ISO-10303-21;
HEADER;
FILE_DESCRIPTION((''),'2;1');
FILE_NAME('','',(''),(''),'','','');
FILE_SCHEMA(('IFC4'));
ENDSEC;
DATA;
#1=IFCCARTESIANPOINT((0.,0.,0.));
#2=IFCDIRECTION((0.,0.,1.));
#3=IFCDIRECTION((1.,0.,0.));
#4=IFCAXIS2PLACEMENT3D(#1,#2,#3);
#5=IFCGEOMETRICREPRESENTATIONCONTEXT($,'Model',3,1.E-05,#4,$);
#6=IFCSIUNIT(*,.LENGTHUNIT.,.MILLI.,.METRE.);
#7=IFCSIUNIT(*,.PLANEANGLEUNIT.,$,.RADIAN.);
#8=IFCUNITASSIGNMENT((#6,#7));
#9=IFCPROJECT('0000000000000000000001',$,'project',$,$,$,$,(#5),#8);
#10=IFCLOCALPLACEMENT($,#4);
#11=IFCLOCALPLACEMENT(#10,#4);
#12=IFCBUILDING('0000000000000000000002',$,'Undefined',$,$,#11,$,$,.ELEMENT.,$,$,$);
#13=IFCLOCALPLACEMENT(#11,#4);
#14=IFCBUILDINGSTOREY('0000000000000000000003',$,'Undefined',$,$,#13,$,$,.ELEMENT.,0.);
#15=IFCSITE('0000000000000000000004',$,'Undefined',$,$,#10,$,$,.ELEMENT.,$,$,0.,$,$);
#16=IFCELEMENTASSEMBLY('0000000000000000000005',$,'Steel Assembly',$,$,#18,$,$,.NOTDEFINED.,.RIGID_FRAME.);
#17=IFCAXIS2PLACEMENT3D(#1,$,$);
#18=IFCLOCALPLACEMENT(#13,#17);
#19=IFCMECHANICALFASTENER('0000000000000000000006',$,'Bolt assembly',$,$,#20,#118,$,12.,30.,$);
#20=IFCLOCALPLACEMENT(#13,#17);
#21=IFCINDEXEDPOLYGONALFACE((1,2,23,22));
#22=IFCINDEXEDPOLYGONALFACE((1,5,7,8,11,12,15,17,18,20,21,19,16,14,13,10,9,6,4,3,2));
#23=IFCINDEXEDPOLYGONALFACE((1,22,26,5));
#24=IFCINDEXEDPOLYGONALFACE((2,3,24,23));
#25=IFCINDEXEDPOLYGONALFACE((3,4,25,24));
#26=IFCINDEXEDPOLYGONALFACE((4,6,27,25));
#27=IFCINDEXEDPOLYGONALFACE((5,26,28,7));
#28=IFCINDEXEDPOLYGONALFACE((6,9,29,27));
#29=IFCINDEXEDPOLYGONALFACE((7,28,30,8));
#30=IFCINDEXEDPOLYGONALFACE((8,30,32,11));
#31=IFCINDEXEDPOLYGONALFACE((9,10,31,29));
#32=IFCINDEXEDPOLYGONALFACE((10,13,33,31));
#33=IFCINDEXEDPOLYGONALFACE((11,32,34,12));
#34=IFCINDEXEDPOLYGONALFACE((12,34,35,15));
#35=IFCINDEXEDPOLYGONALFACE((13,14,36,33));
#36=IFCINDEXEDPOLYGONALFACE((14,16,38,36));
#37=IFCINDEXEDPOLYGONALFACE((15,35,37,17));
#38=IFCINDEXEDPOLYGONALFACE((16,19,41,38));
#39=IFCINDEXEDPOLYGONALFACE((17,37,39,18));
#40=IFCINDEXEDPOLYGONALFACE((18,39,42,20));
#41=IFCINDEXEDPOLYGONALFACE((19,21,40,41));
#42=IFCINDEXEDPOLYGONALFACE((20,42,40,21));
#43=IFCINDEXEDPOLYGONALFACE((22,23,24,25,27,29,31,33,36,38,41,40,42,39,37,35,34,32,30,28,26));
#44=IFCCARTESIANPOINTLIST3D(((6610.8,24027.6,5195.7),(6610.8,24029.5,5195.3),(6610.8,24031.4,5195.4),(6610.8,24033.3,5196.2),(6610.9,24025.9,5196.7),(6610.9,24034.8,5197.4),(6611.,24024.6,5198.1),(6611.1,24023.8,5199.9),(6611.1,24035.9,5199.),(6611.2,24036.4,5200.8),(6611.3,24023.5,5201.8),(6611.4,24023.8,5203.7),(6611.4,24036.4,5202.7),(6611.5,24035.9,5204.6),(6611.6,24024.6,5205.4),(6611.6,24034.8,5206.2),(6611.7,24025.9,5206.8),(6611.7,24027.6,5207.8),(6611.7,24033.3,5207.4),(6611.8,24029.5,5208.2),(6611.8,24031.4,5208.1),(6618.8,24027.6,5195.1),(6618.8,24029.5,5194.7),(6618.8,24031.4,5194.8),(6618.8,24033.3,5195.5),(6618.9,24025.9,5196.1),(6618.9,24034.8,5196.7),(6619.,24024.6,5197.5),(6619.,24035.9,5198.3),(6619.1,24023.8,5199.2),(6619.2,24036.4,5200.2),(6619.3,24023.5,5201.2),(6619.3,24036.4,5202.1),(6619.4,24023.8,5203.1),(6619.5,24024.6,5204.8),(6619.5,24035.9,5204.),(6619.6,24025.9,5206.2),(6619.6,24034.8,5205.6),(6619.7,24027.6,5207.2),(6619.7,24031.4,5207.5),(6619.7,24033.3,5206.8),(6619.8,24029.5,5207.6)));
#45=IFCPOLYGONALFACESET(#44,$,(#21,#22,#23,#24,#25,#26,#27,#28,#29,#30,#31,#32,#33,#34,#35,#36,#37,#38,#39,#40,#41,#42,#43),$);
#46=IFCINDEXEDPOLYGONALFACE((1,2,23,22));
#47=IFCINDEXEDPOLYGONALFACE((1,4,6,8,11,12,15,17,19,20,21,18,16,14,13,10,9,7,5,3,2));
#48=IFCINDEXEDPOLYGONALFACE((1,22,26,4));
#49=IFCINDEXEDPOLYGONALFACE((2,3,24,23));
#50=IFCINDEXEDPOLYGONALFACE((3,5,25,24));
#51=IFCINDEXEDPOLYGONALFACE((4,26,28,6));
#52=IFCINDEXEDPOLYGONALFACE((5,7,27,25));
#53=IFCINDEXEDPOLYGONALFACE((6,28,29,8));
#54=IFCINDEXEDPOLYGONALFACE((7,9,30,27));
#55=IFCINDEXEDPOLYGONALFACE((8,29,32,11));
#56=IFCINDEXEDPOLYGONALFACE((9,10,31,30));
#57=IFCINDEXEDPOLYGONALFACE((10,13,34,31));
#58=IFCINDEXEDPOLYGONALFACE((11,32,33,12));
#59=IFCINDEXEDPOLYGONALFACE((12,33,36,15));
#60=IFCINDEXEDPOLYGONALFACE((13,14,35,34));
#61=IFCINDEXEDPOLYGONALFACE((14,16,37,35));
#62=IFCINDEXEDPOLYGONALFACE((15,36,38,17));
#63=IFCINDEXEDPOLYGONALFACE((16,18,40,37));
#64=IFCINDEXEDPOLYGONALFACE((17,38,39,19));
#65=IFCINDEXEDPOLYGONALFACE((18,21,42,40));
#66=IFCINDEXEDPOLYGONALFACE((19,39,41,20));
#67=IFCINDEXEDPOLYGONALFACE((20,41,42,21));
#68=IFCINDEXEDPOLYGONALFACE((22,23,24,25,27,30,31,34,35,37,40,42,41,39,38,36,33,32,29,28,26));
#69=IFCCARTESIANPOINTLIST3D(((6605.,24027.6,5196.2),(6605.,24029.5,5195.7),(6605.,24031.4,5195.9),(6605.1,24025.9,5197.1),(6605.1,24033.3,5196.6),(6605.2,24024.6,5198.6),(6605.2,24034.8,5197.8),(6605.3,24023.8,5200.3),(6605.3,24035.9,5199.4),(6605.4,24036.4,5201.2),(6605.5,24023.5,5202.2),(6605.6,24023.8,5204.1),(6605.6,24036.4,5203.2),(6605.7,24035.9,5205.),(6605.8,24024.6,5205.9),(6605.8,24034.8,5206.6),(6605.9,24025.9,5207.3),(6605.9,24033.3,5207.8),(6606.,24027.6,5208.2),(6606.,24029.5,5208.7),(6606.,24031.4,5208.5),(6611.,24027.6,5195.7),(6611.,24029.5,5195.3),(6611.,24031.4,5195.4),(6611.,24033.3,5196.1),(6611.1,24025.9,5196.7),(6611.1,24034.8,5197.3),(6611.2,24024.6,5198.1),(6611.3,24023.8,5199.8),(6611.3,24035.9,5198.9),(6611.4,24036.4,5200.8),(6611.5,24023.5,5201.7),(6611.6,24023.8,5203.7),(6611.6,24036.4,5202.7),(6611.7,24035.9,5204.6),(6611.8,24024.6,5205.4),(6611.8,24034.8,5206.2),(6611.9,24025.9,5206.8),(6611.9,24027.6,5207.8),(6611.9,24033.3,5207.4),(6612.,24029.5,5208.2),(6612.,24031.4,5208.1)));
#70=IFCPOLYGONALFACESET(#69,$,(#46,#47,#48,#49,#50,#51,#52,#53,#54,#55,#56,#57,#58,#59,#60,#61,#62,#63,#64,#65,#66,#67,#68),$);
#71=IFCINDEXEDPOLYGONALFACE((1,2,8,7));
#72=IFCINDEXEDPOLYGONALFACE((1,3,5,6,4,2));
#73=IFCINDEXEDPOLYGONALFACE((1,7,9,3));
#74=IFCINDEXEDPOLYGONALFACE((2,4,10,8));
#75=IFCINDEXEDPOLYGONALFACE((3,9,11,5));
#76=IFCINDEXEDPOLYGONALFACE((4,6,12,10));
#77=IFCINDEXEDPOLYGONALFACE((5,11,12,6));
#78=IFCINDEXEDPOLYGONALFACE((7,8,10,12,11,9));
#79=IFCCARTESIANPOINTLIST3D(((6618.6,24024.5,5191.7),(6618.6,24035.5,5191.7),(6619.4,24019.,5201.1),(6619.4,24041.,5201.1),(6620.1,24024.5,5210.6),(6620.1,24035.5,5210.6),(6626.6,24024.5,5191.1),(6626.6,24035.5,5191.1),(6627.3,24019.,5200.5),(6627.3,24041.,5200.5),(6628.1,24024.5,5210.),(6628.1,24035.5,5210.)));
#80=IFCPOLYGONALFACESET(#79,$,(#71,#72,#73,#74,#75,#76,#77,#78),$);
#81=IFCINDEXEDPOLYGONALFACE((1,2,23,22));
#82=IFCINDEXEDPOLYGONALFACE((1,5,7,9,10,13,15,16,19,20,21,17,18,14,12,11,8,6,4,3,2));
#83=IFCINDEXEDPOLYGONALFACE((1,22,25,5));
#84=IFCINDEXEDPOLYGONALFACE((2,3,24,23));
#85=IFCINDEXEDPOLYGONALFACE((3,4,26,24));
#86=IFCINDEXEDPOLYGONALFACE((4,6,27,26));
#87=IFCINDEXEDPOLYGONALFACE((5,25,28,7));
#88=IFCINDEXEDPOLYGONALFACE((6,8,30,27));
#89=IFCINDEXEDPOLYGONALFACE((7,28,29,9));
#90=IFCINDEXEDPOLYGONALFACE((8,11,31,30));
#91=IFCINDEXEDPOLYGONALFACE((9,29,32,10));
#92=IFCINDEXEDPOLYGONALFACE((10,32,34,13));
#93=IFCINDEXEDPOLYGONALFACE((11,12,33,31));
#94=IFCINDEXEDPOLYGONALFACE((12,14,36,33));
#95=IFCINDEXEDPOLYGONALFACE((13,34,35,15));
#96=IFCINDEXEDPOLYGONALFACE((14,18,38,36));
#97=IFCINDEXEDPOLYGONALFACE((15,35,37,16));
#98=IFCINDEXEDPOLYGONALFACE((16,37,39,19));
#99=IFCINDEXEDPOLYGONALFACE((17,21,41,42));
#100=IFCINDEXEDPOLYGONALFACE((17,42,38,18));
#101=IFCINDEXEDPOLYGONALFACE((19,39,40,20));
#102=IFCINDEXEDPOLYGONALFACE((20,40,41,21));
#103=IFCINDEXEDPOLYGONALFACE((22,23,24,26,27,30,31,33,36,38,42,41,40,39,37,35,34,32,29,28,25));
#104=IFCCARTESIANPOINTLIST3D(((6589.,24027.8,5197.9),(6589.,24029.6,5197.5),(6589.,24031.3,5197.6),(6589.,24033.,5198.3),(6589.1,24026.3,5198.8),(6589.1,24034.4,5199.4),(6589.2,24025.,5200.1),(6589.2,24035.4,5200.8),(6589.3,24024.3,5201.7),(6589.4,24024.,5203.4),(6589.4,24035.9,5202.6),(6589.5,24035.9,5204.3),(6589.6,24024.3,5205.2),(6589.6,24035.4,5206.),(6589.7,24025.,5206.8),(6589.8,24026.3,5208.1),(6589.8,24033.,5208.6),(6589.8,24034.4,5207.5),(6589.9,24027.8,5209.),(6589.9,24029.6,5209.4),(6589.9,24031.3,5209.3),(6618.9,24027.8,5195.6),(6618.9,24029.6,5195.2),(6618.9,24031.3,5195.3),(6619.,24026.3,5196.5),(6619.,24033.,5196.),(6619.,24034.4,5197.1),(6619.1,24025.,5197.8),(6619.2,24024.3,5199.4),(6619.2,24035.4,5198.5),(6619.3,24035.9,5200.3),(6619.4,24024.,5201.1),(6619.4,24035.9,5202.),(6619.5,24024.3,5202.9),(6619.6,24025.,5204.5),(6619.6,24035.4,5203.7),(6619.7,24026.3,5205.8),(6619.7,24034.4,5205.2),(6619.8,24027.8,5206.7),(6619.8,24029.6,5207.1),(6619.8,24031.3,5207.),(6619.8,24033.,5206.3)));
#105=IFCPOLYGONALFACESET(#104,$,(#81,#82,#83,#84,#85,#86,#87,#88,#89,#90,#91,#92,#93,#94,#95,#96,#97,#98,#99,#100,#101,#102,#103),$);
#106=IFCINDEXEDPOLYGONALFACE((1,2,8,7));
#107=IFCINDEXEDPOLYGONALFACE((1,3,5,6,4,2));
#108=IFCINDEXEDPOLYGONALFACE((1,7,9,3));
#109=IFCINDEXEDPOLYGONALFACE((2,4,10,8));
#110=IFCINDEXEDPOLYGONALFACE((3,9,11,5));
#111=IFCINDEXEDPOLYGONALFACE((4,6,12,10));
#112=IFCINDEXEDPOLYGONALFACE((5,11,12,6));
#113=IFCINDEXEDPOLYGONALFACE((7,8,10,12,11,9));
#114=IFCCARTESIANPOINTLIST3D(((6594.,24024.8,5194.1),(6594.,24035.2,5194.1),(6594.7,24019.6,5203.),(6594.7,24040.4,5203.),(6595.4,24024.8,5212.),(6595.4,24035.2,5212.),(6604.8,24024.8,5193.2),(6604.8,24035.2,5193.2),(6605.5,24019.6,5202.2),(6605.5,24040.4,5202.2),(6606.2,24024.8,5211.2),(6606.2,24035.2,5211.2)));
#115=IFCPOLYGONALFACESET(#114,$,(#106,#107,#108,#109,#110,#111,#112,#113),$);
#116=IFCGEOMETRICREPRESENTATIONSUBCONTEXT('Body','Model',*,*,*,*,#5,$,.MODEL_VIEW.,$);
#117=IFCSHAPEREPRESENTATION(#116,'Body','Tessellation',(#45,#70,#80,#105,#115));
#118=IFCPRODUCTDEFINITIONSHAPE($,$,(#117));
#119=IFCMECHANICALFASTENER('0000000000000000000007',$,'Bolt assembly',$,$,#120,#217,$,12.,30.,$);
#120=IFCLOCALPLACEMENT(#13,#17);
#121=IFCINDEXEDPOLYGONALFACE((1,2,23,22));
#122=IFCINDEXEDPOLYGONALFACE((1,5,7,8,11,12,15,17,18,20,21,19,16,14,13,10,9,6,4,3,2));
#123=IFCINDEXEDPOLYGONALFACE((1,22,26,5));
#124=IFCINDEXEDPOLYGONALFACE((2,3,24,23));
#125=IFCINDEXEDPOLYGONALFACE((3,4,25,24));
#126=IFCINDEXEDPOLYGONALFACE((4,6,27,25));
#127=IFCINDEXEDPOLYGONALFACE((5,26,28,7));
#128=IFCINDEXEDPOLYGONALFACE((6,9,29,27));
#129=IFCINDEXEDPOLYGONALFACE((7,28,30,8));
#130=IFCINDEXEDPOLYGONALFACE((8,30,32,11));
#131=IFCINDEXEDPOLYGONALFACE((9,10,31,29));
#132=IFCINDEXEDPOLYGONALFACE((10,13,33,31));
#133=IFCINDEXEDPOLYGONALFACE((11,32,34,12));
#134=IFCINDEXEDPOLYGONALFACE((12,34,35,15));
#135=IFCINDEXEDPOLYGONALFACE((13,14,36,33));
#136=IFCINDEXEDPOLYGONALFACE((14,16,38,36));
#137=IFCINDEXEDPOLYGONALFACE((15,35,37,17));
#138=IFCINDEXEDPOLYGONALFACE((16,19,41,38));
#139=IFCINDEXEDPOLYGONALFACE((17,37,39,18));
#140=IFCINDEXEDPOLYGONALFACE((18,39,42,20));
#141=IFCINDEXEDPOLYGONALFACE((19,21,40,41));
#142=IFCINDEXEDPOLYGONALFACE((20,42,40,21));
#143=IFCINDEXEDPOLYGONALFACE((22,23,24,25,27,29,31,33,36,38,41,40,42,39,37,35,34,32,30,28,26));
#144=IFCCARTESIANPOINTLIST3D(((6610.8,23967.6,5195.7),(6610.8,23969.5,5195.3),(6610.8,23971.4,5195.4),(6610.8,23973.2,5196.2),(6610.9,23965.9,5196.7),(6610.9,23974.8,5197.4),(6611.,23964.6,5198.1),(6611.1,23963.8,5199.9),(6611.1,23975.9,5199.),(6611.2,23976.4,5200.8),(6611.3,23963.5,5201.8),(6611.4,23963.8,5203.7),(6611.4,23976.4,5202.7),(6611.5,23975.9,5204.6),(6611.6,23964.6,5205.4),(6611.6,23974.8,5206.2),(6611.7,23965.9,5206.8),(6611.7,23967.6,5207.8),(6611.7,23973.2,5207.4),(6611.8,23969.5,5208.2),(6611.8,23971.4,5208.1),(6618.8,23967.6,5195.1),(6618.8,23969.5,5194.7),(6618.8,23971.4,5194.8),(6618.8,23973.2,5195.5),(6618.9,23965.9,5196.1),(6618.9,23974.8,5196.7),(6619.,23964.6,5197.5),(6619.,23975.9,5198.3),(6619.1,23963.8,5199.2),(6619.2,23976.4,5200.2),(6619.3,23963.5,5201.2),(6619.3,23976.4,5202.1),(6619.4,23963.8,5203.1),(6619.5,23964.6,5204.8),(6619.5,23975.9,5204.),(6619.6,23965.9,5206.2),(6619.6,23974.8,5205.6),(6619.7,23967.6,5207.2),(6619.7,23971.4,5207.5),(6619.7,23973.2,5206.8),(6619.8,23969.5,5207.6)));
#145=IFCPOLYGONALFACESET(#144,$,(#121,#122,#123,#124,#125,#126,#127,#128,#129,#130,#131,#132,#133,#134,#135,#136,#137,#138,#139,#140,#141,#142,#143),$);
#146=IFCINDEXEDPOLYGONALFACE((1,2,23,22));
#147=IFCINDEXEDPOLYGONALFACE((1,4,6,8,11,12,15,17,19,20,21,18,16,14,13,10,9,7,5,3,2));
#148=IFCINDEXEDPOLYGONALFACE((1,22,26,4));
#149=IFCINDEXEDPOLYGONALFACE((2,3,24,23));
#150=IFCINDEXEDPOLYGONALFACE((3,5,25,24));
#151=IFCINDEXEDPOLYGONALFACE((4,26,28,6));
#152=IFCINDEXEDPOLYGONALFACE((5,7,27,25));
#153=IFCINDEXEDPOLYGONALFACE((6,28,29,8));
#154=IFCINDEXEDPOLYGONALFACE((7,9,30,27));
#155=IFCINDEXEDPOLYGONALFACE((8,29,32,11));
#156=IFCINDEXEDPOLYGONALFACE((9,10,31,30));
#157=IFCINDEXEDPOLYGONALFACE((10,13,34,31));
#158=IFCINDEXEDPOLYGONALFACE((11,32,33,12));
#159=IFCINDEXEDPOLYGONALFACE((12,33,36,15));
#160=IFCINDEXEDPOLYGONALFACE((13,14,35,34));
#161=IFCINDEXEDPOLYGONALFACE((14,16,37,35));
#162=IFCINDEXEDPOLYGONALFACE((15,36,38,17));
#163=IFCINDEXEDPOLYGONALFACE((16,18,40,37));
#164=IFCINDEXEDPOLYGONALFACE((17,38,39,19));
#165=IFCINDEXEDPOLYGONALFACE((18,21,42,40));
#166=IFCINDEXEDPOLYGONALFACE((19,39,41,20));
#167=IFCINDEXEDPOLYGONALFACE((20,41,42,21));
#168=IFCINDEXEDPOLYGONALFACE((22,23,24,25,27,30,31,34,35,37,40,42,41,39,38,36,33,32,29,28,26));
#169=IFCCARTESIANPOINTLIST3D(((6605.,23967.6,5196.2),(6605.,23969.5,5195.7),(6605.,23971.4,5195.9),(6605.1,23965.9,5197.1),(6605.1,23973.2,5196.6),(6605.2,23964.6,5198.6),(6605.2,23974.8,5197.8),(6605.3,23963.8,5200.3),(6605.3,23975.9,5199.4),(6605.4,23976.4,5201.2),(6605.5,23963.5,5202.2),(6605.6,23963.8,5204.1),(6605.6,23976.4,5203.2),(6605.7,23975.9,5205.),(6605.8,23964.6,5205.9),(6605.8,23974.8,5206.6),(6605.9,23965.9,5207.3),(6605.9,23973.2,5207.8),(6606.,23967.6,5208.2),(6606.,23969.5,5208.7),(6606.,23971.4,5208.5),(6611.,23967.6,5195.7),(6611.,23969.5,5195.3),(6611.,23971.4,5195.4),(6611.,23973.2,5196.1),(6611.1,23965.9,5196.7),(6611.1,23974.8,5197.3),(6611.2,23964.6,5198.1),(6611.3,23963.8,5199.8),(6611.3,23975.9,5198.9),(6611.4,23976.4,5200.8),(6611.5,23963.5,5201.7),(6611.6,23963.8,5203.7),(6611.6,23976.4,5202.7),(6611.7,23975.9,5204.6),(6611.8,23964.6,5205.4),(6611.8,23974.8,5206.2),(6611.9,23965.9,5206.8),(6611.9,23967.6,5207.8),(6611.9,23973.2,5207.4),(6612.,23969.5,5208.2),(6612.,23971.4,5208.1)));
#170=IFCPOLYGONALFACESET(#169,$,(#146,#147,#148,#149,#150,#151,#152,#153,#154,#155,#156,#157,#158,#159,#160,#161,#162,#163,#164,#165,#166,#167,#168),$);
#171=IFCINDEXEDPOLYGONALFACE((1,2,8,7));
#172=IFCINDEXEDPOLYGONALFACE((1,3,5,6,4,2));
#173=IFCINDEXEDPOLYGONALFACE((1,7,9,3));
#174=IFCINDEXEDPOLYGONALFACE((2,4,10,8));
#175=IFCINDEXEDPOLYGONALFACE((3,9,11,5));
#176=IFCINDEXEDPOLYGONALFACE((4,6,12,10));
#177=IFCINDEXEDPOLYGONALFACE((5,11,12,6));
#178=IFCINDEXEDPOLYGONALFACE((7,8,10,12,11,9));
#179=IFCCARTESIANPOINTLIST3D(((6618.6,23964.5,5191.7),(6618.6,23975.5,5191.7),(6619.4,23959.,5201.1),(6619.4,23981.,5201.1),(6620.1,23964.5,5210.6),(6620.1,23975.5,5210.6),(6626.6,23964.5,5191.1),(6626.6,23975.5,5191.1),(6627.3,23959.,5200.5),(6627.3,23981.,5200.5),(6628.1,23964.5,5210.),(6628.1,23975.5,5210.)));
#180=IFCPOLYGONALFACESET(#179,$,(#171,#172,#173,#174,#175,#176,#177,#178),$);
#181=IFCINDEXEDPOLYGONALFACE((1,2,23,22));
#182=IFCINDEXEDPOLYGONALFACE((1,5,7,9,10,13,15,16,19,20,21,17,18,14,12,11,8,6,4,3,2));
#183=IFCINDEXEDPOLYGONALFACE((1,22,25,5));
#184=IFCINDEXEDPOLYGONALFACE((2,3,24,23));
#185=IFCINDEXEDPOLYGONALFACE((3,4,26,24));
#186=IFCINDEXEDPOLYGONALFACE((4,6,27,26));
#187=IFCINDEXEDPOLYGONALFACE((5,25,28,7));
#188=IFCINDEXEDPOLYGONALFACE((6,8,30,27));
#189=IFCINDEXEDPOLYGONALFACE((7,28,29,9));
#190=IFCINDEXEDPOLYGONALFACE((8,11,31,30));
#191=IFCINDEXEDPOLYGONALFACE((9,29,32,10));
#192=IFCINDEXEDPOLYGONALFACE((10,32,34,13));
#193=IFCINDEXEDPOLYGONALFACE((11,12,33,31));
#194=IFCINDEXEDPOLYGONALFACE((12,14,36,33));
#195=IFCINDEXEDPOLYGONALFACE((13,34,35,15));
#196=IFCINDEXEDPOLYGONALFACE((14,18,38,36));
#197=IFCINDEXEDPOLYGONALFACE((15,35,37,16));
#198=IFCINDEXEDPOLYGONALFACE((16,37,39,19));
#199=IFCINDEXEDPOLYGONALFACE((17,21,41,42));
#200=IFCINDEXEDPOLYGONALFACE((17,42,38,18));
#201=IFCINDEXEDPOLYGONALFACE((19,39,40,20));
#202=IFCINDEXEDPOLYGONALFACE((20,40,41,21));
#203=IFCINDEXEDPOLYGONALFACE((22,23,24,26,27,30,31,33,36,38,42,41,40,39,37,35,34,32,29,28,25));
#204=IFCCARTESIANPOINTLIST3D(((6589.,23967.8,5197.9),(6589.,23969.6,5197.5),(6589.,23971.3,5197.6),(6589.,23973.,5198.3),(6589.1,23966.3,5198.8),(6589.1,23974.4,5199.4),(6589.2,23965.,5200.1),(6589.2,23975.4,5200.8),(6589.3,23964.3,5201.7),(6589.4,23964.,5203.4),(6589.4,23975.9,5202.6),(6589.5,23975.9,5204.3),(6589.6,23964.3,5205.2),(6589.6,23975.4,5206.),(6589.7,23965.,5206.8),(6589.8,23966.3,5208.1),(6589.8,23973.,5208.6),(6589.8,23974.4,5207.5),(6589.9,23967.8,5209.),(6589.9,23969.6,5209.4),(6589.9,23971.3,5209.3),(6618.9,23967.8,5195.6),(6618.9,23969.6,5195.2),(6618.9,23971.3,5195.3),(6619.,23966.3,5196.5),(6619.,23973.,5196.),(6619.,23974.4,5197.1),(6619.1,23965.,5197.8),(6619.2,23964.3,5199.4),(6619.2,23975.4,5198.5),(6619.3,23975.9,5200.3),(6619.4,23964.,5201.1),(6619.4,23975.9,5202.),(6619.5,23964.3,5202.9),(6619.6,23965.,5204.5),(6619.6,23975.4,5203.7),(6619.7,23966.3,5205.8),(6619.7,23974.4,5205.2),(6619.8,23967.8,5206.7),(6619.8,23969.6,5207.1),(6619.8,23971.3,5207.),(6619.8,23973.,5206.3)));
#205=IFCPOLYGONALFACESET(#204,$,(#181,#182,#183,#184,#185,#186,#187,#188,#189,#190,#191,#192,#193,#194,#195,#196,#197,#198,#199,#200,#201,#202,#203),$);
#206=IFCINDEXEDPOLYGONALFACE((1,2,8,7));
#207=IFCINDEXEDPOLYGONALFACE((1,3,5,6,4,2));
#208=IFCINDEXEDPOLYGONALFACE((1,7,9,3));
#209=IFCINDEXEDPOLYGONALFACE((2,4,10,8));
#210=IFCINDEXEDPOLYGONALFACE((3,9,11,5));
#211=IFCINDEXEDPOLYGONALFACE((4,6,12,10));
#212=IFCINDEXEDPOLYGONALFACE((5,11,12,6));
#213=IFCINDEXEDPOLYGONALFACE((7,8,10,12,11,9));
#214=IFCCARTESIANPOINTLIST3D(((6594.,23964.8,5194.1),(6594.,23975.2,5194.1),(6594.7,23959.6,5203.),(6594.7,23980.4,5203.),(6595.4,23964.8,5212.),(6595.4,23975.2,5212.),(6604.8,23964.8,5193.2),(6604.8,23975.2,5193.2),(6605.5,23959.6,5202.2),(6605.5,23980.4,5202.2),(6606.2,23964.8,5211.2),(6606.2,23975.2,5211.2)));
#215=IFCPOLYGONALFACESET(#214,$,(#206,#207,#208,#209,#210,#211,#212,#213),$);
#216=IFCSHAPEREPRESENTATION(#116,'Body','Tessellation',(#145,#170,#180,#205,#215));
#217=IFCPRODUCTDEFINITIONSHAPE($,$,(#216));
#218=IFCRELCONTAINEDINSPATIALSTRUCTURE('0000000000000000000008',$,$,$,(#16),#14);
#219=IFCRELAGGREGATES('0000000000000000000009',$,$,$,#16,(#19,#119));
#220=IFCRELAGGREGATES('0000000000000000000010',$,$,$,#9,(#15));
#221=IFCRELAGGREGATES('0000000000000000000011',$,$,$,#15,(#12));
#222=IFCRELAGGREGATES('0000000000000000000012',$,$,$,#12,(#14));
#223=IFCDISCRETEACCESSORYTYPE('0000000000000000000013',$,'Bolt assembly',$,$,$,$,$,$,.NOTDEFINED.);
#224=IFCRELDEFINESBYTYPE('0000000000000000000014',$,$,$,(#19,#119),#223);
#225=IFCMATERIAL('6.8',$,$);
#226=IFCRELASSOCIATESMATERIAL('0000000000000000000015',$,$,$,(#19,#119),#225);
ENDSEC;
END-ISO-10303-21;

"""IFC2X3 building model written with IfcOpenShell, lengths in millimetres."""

from ifc_helpers import new_model, si_unit, frame, origin_with_axes, origin_2d_with_axis, place, context, subcontext, project, spatial, polyline, circle, outline, extrude, source, transform, mapped, material, type_object, element, aggregate, save


model = new_model("IFC2X3")

# Units and contexts
model_context = context("Model", 3, precision=1e-05, world=origin_with_axes())
body_context = subcontext(model_context, "Body", "Model", "MODEL_VIEW")
ifc_project = project(units=[si_unit("LENGTHUNIT", "METRE", prefix="MILLI"), si_unit("PLANEANGLEUNIT", "RADIAN")], contexts=[model_context])

# Site, building, storey
site_placement = place(None, origin_with_axes())
site = spatial("IfcSite", under=ifc_project, at=site_placement, Name="Undefined", CompositionType="ELEMENT", RefElevation=0.0)
building_placement = place(site_placement, origin_with_axes())
building = spatial("IfcBuilding", under=site, at=building_placement, Name="Undefined", CompositionType="ELEMENT")
storey_placement = place(building_placement, origin_with_axes())
storey = spatial("IfcBuildingStorey", under=building, at=storey_placement, Name="Undefined", CompositionType="ELEMENT", Elevation=0.0)

# Element assembly
assembly_1_placement = place(storey_placement, origin_with_axes())
assembly_1 = element("IfcElementAssembly", 1, at=assembly_1_placement, inside=storey, Name="Steel Assembly", AssemblyPlace="NOTDEFINED", PredefinedType="RIGID_FRAME")

# Shared definitions
ifc_material_1 = material(Name="6.8")
discrete_accessory_type_1 = type_object("IfcDiscreteAccessoryType", Name="Bolt assembly")

# Mechanical fasteners
shared_shape_1 = source(origin_with_axes(), body_context, "Body", "SweptSolid", [
    extrude(circle(Radius=6.5, at=origin_2d_with_axis()), frame((0.0, -10.9, 0.0), z_axis=(0.0, 1.0, 0.0), x_axis=(1.0, 0.0, 0.0)), (0.0, 0.0, 1.0), 8.0),
    extrude(circle(Radius=6.5, at=origin_2d_with_axis()), frame((0.0, -3.1, 0.0), z_axis=(0.0, 1.0, 0.0), x_axis=(1.0, 0.0, 0.0)), (0.0, 0.0, 1.0), 6.0),
    extrude(outline(polyline([(11.0, 0.0), (5.5, 9.5), (-5.5, 9.5), (-11.0, 0.0), (-5.5, -9.5), (5.5, -9.5), (11.0, 0.0)])), frame((0.0, -19.0, 0.0), z_axis=(0.0, 1.0, 0.0), x_axis=(1.0, 0.0, 0.0)), (0.0, 0.0, 1.0), 8.0),
    extrude(circle(Radius=6.0, at=origin_2d_with_axis()), frame((0.0, -11.0, 0.0), z_axis=(0.0, 1.0, 0.0), x_axis=(1.0, 0.0, 0.0)), (0.0, 0.0, 1.0), 30.0),
    extrude(outline(polyline([(10.4, 0.0), (5.2, 9.0), (-5.2, 9.0), (-10.4, 0.0), (-5.2, -9.0), (5.2, -9.0), (10.4, 0.0)])), frame((0.0, 3.0, 0.0), z_axis=(0.0, 1.0, 0.0), x_axis=(1.0, 0.0, 0.0)), (0.0, 0.0, 1.0), 10.8),
])
mechanical_fastener_1_placement = place(assembly_1_placement, frame((6608.4, 24030.0, 5202.0), z_axis=(-0.076696, 0.0, -0.997054), x_axis=(0.0, -1.0, 0.0)))
mechanical_fastener_1 = element("IfcMechanicalFastener", 2, at=mechanical_fastener_1_placement, type_object=discrete_accessory_type_1, material=ifc_material_1, Name="Bolt assembly", NominalDiameter=12.0, NominalLength=30.0, context=body_context, shape_type="MappedRepresentation", body=[
    mapped(shared_shape_1, transform((0.0, 0.0, 0.0))),
])
mechanical_fastener_2_placement = place(assembly_1_placement, frame((6608.4, 23970.0, 5202.0), z_axis=(-0.076696, 0.0, -0.997054), x_axis=(0.0, -1.0, 0.0)))
mechanical_fastener_2 = element("IfcMechanicalFastener", 3, at=mechanical_fastener_2_placement, type_object=discrete_accessory_type_1, material=ifc_material_1, Name="Bolt assembly", NominalDiameter=12.0, NominalLength=30.0, context=body_context, shape_type="MappedRepresentation", body=[
    mapped(shared_shape_1, transform((0.0, 0.0, 0.0))),
])

aggregate(assembly_1, [mechanical_fastener_1, mechanical_fastener_2])

save(model, "model.ifc")
